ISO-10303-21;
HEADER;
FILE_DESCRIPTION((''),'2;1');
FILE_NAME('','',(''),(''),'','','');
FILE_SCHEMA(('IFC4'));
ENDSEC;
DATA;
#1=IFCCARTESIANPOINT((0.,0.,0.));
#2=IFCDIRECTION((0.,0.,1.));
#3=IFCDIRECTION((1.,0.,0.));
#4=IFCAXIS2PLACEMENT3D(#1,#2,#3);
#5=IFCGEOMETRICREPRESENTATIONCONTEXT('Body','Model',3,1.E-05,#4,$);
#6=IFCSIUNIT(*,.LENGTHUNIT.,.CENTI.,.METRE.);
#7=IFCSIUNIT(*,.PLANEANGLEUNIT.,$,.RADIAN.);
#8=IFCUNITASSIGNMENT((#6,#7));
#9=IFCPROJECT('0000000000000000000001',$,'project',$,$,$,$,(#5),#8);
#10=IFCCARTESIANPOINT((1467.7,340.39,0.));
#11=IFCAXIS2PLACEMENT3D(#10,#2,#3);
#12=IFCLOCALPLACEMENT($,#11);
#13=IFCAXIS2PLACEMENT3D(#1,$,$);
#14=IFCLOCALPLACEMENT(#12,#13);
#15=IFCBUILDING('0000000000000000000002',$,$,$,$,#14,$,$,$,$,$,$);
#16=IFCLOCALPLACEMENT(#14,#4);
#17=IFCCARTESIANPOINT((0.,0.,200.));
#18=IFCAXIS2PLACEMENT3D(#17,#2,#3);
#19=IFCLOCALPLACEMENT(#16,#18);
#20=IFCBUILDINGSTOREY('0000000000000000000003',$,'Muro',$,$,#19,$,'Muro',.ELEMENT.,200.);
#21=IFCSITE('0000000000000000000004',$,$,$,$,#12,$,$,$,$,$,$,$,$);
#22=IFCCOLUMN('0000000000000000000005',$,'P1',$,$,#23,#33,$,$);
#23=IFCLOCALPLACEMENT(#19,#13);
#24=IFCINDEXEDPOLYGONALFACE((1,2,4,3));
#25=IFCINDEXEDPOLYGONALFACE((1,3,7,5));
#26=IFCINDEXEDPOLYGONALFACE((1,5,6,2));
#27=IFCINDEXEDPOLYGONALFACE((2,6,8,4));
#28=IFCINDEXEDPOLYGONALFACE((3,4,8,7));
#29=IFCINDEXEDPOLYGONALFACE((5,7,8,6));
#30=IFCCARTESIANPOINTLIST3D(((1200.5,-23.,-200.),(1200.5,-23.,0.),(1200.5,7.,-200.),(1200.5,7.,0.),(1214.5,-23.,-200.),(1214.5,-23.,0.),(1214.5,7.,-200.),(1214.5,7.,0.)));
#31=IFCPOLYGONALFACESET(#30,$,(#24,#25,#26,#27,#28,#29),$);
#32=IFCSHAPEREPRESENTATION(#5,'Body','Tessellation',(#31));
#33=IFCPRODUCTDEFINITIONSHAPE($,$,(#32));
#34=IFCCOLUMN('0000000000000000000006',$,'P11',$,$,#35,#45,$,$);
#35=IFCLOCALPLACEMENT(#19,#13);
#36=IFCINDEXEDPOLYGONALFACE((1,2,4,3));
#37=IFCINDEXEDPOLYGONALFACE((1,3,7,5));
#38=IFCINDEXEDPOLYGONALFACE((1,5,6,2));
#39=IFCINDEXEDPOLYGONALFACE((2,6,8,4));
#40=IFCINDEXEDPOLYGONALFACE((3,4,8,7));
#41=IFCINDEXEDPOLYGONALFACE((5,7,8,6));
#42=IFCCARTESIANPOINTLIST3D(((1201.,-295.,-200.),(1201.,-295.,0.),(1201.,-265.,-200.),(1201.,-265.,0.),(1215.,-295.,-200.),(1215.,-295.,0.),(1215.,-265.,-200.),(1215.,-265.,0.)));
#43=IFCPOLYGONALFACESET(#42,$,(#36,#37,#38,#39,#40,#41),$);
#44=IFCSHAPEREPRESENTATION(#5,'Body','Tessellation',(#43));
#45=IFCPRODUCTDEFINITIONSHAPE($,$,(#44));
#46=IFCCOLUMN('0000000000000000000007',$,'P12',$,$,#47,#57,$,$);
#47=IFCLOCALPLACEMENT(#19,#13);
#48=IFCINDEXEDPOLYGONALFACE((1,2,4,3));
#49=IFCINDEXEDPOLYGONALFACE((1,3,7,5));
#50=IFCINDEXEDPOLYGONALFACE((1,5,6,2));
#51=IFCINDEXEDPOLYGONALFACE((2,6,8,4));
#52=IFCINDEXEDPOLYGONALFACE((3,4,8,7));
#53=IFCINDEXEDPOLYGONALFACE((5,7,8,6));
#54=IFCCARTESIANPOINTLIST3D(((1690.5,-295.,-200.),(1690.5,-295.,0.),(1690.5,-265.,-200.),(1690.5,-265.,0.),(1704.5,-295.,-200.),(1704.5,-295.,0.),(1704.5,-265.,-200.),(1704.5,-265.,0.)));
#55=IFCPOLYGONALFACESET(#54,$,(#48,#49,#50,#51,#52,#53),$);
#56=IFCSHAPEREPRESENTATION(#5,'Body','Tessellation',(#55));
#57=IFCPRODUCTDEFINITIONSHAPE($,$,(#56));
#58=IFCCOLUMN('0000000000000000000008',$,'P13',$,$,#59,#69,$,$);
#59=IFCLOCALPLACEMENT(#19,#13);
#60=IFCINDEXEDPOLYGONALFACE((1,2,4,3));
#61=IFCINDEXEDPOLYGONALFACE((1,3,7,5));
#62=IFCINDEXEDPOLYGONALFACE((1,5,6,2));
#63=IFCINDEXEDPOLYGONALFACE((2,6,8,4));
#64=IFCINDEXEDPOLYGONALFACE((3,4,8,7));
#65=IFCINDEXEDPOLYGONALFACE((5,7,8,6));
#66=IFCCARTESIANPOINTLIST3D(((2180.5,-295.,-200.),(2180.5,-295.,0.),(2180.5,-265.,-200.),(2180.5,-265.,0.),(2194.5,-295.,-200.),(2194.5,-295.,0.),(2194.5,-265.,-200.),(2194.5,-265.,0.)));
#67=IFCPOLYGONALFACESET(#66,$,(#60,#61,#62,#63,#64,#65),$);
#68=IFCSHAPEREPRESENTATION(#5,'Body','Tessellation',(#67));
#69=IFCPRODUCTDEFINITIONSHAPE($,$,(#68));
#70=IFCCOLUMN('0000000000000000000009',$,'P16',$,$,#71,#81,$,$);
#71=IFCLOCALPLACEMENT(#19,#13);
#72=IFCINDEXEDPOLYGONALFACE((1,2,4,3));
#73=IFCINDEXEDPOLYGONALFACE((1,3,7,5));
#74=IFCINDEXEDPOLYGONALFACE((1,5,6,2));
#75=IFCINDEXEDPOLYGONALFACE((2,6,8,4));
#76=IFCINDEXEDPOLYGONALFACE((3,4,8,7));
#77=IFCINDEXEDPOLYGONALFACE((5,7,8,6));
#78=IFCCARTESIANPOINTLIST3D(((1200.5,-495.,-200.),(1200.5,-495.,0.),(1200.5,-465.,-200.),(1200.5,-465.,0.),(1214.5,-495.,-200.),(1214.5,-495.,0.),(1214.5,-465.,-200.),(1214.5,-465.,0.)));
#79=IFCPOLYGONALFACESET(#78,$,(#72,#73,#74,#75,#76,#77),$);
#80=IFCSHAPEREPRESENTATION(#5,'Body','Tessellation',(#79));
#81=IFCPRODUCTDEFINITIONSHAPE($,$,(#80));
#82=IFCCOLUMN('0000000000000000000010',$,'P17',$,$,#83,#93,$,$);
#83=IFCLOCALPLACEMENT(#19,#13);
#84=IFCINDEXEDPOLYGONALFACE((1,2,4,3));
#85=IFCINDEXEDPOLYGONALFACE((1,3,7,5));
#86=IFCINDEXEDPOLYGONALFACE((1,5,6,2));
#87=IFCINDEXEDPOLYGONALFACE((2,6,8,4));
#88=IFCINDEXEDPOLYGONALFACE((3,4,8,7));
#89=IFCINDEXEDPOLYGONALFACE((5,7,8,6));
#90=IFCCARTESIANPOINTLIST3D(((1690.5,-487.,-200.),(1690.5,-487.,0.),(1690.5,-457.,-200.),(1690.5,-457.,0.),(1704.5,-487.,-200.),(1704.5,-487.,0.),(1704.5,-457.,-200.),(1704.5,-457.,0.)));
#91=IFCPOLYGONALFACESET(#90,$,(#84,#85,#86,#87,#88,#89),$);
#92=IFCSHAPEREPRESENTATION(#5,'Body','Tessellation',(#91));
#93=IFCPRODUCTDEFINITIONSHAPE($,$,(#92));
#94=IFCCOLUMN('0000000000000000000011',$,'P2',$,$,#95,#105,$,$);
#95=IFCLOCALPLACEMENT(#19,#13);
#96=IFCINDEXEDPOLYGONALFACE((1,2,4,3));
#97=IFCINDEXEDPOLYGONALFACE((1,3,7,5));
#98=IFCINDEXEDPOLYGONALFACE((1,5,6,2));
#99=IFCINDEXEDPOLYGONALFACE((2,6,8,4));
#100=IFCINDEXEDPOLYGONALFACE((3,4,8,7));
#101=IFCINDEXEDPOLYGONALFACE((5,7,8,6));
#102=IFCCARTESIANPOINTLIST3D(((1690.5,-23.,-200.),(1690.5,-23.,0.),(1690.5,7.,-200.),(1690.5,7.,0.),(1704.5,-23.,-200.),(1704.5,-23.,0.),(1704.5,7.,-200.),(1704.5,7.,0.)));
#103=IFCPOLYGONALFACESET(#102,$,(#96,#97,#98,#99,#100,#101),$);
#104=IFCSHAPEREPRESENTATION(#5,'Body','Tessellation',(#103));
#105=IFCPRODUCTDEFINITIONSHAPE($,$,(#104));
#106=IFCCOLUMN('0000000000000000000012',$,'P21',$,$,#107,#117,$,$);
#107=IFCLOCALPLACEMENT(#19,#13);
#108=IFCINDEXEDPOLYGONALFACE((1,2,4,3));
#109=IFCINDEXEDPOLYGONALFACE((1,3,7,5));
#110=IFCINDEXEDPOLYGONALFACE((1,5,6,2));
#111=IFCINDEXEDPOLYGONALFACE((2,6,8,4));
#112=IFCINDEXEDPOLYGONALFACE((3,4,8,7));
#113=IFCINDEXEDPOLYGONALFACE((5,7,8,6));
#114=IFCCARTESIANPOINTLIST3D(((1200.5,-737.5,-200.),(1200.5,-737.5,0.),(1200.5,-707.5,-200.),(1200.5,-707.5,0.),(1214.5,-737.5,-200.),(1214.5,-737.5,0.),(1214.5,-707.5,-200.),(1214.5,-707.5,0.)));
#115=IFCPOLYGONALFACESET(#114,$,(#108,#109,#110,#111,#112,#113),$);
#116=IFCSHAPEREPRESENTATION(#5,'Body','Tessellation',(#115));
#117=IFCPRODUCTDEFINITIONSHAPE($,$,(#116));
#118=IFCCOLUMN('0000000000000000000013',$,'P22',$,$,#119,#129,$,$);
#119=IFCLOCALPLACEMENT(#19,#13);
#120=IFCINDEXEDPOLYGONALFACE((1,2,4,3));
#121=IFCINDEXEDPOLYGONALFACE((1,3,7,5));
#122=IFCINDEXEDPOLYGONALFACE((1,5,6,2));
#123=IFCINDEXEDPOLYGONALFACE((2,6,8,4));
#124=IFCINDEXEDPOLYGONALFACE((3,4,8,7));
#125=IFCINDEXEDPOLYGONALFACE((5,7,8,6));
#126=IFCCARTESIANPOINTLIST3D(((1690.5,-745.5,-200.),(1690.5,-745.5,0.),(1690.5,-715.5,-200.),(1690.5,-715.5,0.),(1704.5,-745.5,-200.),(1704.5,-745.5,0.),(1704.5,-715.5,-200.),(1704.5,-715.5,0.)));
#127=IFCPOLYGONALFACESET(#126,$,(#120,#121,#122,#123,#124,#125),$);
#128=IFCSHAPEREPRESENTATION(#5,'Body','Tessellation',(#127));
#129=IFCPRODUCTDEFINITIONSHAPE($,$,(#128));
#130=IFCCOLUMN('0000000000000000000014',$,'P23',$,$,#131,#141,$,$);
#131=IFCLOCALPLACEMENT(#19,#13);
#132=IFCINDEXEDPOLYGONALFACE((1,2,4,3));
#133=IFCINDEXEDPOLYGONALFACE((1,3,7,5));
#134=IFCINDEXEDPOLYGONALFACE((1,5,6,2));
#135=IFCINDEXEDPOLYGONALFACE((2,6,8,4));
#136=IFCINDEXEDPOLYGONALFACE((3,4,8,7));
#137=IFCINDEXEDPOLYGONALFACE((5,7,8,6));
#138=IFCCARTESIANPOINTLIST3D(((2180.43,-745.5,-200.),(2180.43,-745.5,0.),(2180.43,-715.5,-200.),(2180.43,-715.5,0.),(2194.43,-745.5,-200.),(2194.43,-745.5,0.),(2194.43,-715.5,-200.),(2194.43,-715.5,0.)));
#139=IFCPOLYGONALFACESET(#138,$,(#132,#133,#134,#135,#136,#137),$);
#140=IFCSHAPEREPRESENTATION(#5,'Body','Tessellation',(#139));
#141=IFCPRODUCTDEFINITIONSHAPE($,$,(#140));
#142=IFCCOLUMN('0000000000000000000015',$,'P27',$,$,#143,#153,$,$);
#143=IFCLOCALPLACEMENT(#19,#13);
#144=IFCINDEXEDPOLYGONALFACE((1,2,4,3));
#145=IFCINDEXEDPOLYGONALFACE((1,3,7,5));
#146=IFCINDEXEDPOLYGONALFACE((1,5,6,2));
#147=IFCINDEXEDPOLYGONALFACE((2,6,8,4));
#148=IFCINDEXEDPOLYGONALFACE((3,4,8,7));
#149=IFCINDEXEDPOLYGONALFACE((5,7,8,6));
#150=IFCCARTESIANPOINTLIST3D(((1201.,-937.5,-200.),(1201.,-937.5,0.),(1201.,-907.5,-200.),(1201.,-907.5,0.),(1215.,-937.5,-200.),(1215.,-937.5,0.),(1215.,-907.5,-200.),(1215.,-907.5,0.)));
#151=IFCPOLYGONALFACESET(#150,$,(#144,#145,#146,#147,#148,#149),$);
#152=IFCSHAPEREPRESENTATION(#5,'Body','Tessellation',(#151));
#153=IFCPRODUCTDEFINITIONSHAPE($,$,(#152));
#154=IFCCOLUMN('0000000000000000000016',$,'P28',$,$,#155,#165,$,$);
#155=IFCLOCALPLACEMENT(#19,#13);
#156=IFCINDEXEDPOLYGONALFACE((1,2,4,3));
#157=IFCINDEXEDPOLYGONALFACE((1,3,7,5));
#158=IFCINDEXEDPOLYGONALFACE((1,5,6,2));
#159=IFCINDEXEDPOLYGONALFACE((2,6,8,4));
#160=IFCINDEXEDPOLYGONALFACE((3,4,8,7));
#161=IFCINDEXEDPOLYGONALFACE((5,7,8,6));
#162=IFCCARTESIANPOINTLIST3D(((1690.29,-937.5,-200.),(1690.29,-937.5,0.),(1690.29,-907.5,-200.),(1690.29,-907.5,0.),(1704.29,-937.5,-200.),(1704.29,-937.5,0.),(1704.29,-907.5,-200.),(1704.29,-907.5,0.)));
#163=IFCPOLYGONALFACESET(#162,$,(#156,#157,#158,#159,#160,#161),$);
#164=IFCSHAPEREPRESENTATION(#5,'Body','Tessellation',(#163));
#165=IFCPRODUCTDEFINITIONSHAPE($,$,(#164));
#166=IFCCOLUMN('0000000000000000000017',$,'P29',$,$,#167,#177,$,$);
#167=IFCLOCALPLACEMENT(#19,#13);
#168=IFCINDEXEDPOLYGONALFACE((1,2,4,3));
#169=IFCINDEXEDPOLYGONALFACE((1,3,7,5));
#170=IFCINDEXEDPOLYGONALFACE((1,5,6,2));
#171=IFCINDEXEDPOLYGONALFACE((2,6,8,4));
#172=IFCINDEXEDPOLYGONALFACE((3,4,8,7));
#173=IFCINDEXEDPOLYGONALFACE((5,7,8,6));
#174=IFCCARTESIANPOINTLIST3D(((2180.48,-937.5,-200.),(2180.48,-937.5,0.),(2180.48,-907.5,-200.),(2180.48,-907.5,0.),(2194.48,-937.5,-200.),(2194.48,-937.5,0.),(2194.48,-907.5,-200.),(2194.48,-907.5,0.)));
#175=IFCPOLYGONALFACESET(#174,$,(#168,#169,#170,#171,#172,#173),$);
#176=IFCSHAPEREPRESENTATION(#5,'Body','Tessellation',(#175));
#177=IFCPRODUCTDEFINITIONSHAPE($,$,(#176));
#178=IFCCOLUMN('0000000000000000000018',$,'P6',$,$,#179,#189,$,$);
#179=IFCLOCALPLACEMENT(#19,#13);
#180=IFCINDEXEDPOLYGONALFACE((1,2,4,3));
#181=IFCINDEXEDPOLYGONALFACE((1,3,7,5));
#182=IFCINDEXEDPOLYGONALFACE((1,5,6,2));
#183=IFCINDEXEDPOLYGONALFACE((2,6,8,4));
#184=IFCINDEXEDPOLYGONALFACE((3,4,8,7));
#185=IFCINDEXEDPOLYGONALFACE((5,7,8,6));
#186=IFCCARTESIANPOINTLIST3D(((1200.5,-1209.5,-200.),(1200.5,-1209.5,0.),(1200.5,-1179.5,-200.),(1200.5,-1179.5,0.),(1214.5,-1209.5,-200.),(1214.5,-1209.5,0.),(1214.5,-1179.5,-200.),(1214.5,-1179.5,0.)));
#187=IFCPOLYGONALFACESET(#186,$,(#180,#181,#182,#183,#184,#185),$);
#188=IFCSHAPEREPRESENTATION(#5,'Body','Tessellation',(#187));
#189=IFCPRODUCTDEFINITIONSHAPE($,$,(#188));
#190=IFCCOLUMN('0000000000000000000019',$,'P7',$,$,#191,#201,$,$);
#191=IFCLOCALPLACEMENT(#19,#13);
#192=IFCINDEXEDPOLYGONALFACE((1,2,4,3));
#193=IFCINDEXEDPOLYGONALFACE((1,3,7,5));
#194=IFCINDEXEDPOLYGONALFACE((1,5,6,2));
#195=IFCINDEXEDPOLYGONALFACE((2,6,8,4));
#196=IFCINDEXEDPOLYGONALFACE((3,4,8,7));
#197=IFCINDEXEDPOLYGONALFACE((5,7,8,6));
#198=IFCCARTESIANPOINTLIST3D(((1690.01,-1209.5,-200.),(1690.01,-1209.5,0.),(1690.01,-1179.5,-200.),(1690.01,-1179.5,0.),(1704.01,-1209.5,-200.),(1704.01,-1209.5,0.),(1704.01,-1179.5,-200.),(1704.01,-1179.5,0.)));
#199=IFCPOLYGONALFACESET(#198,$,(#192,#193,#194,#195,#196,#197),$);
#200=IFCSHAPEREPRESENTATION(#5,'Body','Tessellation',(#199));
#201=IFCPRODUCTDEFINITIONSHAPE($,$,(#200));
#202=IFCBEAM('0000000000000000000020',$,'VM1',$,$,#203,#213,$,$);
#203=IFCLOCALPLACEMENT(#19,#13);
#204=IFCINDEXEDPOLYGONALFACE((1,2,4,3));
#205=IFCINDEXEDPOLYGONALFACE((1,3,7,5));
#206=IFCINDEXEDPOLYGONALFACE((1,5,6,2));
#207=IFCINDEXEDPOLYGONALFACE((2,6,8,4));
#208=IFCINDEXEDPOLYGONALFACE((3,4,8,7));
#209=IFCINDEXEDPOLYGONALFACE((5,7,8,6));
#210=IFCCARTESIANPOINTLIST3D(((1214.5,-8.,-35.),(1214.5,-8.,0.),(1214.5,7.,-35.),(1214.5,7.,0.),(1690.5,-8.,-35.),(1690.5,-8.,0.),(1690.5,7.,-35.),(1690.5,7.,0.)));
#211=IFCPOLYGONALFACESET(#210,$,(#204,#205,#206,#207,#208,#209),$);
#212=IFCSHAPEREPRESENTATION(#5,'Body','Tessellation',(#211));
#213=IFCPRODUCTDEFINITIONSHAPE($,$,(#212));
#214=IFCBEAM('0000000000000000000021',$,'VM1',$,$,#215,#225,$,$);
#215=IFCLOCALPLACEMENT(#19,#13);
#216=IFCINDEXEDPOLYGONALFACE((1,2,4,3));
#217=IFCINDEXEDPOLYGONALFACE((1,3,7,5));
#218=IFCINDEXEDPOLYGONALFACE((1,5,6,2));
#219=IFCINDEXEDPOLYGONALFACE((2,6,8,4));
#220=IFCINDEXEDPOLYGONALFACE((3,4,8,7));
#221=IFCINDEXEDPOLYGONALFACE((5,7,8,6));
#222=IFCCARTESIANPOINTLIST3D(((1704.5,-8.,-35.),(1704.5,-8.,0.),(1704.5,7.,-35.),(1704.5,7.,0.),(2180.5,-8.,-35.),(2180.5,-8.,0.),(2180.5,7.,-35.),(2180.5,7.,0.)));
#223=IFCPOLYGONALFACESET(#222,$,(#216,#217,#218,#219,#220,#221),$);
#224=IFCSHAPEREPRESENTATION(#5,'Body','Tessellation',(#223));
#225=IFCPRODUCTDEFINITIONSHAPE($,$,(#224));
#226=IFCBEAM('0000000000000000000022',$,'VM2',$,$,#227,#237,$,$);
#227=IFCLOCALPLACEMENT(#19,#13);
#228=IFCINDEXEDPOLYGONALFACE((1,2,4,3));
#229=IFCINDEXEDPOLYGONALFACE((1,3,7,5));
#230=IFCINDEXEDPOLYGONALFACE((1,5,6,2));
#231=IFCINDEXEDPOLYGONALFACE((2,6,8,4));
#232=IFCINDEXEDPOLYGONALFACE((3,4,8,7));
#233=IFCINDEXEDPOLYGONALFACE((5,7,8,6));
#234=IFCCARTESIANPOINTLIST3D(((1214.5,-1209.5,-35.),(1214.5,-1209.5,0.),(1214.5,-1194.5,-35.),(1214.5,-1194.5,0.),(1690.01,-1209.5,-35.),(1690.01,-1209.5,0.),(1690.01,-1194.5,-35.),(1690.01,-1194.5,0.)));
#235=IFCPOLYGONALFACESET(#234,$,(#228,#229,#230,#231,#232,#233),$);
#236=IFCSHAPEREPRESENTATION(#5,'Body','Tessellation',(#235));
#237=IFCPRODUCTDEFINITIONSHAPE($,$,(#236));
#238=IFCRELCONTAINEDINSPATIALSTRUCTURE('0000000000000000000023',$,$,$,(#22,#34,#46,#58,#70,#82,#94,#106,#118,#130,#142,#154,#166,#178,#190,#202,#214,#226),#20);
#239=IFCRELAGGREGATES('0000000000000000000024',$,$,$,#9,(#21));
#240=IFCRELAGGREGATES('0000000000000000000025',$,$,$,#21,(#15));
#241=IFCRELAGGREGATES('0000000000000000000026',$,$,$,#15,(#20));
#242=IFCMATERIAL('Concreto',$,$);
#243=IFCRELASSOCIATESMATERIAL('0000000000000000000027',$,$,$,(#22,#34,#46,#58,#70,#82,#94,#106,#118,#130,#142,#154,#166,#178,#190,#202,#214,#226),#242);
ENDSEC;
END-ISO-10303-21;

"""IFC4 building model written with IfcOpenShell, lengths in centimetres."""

from ifc_helpers import new_model, si_unit, frame, origin, origin_with_axes, origin_2d_with_axis, place, context, project, spatial, rectangle, extrude, material, element, save


model = new_model("IFC4")

# Units and contexts
model_context = context("Model", 3, precision=1e-05, world=origin_with_axes(), identifier="Body")
ifc_project = project(units=[si_unit("LENGTHUNIT", "METRE", prefix="CENTI"), si_unit("PLANEANGLEUNIT", "RADIAN")], contexts=[model_context])

# Site, building, storey
site_placement = place(None, frame((1467.7, 340.39, 0.0), z_axis=(0.0, 0.0, 1.0), x_axis=(1.0, 0.0, 0.0)))
site = spatial("IfcSite", under=ifc_project, at=site_placement)
building_placement = place(site_placement, origin())
building = spatial("IfcBuilding", under=site, at=building_placement)
placement = place(building_placement, origin_with_axes())
storey_placement = place(placement, frame((0.0, 0.0, 200.0), z_axis=(0.0, 0.0, 1.0), x_axis=(1.0, 0.0, 0.0)))
storey = spatial("IfcBuildingStorey", under=building, at=storey_placement, Name="Muro", LongName="Muro", CompositionType="ELEMENT", Elevation=200.0)

# Columns
ifc_material = material(Name="Concreto")
for number, where, z_axis, x_axis, name in (
    (1, (1207.5, -8.0, 0.0), (0.0, 0.0, 1.0), (1.0, 0.0, 0.0), "P1"),
    (2, (1208.0, -280.0, 0.0), (0.0, 0.0, 1.0), (1.0, 0.0, 0.0), "P11"),
    (3, (1697.5, -280.0, 0.0), (0.0, 0.0, 1.0), (1.0, 0.0, 0.0), "P12"),
    (4, (2187.5, -280.0, 0.0), (0.0, 0.0, 1.0), (1.0, 0.0, 0.0), "P13"),
    (5, (1207.5, -480.0, 0.0), (0.0, 0.0, 1.0), (1.0, 0.0, 0.0), "P16"),
):
    element("IfcColumn", number, at=place(storey_placement, frame(where, z_axis=z_axis, x_axis=x_axis)), inside=storey, material=ifc_material, Name=name, context=model_context, shape_type="SolidModel", body=[
        extrude(rectangle(XDim=14.0, YDim=30.0, at=origin_2d_with_axis()), origin_with_axes(), (0.0, 0.0, -1.0), 200.0),
    ])
column_1_placement = place(storey_placement, frame((1697.5, -472.0, 0.0), z_axis=(0.0, 0.0, 1.0), x_axis=(1.0, 0.0, 0.0)))
element("IfcColumn", 6, at=column_1_placement, inside=storey, material=ifc_material, Name="P17", context=model_context, shape_type="SolidModel", body=[
    extrude(rectangle(XDim=14.0, YDim=30.0, at=origin_2d_with_axis()), frame((0.0, 0.0, 0.0), z_axis=(0.0, 0.0, 1.0), x_axis=(-1.0, 0.0, 0.0)), (0.0, 0.0, -1.0), 200.0),
])
for number, where, z_axis, x_axis, name in (
    (7, (1697.5, -8.0, 0.0), (0.0, 0.0, 1.0), (1.0, 0.0, 0.0), "P2"),
    (8, (1207.5, -722.5, 0.0), (0.0, 0.0, 1.0), (1.0, 0.0, 0.0), "P21"),
):
    element("IfcColumn", number, at=place(storey_placement, frame(where, z_axis=z_axis, x_axis=x_axis)), inside=storey, material=ifc_material, Name=name, context=model_context, shape_type="SolidModel", body=[
        extrude(rectangle(XDim=14.0, YDim=30.0, at=origin_2d_with_axis()), origin_with_axes(), (0.0, 0.0, -1.0), 200.0),
    ])
column_2_placement = place(storey_placement, frame((1697.5, -730.5, 0.0), z_axis=(0.0, 0.0, 1.0), x_axis=(1.0, 0.0, 0.0)))
element("IfcColumn", 9, at=column_2_placement, inside=storey, material=ifc_material, Name="P22", context=model_context, shape_type="SolidModel", body=[
    extrude(rectangle(XDim=14.0, YDim=30.0, at=origin_2d_with_axis()), frame((0.0, 0.0, 0.0), z_axis=(0.0, 0.0, 1.0), x_axis=(-1.0, 0.0, 0.0)), (0.0, 0.0, -1.0), 200.0),
])
for number, where, z_axis, x_axis, name in (
    (10, (2187.43, -730.5, 0.0), (0.0, 0.0, 1.0), (1.0, 0.0, 0.0), "P23"),
    (11, (1208.0, -922.5, 0.0), (0.0, 0.0, 1.0), (1.0, 0.0, 0.0), "P27"),
    (12, (1697.29, -922.5, 0.0), (0.0, 0.0, 1.0), (1.0, 0.0, 0.0), "P28"),
    (13, (2187.48, -922.5, 0.0), (0.0, 0.0, 1.0), (1.0, 0.0, 0.0), "P29"),
    (14, (1207.5, -1194.5, 0.0), (0.0, 0.0, 1.0), (1.0, 0.0, 0.0), "P6"),
    (15, (1697.01, -1194.5, 0.0), (0.0, 0.0, 1.0), (1.0, 0.0, 0.0), "P7"),
):
    element("IfcColumn", number, at=place(storey_placement, frame(where, z_axis=z_axis, x_axis=x_axis)), inside=storey, material=ifc_material, Name=name, context=model_context, shape_type="SolidModel", body=[
        extrude(rectangle(XDim=14.0, YDim=30.0, at=origin_2d_with_axis()), origin_with_axes(), (0.0, 0.0, -1.0), 200.0),
    ])

# Beams
for number, where, z_axis, x_axis, name in (
    (16, (1452.5, -0.5, 0.0), (0.0, 0.0, 1.0), (1.0, 0.0, 0.0), "VM1"),
    (17, (1942.5, -0.5, 0.0), (0.0, 0.0, 1.0), (1.0, 0.0, 0.0), "VM1"),
):
    element("IfcBeam", number, at=place(storey_placement, frame(where, z_axis=z_axis, x_axis=x_axis)), inside=storey, material=ifc_material, Name=name, context=model_context, shape_type="SolidModel", body=[
        extrude(rectangle(XDim=15.0, YDim=35.0, at=origin_2d_with_axis()), frame((-238.0, 0.0, -17.5), z_axis=(1.0, 0.0, 0.0), x_axis=(0.0, 1.0, 0.0)), (0.0, 0.0, 1.0), 476.0),
    ])
beam_1_placement = place(storey_placement, frame((1452.26, -1202.0, 0.0), z_axis=(0.0, 0.0, 1.0), x_axis=(1.0, 0.0, 0.0)))
element("IfcBeam", 18, at=beam_1_placement, inside=storey, material=ifc_material, Name="VM2", context=model_context, shape_type="SolidModel", body=[
    extrude(rectangle(XDim=15.0, YDim=35.0, at=origin_2d_with_axis()), frame((-237.75, 0.0, -17.5), z_axis=(1.0, 0.0, 0.0), x_axis=(0.0, -1.0, 0.0)), (0.0, 0.0, 1.0), 475.51),
])

save(model, "model.ifc")
